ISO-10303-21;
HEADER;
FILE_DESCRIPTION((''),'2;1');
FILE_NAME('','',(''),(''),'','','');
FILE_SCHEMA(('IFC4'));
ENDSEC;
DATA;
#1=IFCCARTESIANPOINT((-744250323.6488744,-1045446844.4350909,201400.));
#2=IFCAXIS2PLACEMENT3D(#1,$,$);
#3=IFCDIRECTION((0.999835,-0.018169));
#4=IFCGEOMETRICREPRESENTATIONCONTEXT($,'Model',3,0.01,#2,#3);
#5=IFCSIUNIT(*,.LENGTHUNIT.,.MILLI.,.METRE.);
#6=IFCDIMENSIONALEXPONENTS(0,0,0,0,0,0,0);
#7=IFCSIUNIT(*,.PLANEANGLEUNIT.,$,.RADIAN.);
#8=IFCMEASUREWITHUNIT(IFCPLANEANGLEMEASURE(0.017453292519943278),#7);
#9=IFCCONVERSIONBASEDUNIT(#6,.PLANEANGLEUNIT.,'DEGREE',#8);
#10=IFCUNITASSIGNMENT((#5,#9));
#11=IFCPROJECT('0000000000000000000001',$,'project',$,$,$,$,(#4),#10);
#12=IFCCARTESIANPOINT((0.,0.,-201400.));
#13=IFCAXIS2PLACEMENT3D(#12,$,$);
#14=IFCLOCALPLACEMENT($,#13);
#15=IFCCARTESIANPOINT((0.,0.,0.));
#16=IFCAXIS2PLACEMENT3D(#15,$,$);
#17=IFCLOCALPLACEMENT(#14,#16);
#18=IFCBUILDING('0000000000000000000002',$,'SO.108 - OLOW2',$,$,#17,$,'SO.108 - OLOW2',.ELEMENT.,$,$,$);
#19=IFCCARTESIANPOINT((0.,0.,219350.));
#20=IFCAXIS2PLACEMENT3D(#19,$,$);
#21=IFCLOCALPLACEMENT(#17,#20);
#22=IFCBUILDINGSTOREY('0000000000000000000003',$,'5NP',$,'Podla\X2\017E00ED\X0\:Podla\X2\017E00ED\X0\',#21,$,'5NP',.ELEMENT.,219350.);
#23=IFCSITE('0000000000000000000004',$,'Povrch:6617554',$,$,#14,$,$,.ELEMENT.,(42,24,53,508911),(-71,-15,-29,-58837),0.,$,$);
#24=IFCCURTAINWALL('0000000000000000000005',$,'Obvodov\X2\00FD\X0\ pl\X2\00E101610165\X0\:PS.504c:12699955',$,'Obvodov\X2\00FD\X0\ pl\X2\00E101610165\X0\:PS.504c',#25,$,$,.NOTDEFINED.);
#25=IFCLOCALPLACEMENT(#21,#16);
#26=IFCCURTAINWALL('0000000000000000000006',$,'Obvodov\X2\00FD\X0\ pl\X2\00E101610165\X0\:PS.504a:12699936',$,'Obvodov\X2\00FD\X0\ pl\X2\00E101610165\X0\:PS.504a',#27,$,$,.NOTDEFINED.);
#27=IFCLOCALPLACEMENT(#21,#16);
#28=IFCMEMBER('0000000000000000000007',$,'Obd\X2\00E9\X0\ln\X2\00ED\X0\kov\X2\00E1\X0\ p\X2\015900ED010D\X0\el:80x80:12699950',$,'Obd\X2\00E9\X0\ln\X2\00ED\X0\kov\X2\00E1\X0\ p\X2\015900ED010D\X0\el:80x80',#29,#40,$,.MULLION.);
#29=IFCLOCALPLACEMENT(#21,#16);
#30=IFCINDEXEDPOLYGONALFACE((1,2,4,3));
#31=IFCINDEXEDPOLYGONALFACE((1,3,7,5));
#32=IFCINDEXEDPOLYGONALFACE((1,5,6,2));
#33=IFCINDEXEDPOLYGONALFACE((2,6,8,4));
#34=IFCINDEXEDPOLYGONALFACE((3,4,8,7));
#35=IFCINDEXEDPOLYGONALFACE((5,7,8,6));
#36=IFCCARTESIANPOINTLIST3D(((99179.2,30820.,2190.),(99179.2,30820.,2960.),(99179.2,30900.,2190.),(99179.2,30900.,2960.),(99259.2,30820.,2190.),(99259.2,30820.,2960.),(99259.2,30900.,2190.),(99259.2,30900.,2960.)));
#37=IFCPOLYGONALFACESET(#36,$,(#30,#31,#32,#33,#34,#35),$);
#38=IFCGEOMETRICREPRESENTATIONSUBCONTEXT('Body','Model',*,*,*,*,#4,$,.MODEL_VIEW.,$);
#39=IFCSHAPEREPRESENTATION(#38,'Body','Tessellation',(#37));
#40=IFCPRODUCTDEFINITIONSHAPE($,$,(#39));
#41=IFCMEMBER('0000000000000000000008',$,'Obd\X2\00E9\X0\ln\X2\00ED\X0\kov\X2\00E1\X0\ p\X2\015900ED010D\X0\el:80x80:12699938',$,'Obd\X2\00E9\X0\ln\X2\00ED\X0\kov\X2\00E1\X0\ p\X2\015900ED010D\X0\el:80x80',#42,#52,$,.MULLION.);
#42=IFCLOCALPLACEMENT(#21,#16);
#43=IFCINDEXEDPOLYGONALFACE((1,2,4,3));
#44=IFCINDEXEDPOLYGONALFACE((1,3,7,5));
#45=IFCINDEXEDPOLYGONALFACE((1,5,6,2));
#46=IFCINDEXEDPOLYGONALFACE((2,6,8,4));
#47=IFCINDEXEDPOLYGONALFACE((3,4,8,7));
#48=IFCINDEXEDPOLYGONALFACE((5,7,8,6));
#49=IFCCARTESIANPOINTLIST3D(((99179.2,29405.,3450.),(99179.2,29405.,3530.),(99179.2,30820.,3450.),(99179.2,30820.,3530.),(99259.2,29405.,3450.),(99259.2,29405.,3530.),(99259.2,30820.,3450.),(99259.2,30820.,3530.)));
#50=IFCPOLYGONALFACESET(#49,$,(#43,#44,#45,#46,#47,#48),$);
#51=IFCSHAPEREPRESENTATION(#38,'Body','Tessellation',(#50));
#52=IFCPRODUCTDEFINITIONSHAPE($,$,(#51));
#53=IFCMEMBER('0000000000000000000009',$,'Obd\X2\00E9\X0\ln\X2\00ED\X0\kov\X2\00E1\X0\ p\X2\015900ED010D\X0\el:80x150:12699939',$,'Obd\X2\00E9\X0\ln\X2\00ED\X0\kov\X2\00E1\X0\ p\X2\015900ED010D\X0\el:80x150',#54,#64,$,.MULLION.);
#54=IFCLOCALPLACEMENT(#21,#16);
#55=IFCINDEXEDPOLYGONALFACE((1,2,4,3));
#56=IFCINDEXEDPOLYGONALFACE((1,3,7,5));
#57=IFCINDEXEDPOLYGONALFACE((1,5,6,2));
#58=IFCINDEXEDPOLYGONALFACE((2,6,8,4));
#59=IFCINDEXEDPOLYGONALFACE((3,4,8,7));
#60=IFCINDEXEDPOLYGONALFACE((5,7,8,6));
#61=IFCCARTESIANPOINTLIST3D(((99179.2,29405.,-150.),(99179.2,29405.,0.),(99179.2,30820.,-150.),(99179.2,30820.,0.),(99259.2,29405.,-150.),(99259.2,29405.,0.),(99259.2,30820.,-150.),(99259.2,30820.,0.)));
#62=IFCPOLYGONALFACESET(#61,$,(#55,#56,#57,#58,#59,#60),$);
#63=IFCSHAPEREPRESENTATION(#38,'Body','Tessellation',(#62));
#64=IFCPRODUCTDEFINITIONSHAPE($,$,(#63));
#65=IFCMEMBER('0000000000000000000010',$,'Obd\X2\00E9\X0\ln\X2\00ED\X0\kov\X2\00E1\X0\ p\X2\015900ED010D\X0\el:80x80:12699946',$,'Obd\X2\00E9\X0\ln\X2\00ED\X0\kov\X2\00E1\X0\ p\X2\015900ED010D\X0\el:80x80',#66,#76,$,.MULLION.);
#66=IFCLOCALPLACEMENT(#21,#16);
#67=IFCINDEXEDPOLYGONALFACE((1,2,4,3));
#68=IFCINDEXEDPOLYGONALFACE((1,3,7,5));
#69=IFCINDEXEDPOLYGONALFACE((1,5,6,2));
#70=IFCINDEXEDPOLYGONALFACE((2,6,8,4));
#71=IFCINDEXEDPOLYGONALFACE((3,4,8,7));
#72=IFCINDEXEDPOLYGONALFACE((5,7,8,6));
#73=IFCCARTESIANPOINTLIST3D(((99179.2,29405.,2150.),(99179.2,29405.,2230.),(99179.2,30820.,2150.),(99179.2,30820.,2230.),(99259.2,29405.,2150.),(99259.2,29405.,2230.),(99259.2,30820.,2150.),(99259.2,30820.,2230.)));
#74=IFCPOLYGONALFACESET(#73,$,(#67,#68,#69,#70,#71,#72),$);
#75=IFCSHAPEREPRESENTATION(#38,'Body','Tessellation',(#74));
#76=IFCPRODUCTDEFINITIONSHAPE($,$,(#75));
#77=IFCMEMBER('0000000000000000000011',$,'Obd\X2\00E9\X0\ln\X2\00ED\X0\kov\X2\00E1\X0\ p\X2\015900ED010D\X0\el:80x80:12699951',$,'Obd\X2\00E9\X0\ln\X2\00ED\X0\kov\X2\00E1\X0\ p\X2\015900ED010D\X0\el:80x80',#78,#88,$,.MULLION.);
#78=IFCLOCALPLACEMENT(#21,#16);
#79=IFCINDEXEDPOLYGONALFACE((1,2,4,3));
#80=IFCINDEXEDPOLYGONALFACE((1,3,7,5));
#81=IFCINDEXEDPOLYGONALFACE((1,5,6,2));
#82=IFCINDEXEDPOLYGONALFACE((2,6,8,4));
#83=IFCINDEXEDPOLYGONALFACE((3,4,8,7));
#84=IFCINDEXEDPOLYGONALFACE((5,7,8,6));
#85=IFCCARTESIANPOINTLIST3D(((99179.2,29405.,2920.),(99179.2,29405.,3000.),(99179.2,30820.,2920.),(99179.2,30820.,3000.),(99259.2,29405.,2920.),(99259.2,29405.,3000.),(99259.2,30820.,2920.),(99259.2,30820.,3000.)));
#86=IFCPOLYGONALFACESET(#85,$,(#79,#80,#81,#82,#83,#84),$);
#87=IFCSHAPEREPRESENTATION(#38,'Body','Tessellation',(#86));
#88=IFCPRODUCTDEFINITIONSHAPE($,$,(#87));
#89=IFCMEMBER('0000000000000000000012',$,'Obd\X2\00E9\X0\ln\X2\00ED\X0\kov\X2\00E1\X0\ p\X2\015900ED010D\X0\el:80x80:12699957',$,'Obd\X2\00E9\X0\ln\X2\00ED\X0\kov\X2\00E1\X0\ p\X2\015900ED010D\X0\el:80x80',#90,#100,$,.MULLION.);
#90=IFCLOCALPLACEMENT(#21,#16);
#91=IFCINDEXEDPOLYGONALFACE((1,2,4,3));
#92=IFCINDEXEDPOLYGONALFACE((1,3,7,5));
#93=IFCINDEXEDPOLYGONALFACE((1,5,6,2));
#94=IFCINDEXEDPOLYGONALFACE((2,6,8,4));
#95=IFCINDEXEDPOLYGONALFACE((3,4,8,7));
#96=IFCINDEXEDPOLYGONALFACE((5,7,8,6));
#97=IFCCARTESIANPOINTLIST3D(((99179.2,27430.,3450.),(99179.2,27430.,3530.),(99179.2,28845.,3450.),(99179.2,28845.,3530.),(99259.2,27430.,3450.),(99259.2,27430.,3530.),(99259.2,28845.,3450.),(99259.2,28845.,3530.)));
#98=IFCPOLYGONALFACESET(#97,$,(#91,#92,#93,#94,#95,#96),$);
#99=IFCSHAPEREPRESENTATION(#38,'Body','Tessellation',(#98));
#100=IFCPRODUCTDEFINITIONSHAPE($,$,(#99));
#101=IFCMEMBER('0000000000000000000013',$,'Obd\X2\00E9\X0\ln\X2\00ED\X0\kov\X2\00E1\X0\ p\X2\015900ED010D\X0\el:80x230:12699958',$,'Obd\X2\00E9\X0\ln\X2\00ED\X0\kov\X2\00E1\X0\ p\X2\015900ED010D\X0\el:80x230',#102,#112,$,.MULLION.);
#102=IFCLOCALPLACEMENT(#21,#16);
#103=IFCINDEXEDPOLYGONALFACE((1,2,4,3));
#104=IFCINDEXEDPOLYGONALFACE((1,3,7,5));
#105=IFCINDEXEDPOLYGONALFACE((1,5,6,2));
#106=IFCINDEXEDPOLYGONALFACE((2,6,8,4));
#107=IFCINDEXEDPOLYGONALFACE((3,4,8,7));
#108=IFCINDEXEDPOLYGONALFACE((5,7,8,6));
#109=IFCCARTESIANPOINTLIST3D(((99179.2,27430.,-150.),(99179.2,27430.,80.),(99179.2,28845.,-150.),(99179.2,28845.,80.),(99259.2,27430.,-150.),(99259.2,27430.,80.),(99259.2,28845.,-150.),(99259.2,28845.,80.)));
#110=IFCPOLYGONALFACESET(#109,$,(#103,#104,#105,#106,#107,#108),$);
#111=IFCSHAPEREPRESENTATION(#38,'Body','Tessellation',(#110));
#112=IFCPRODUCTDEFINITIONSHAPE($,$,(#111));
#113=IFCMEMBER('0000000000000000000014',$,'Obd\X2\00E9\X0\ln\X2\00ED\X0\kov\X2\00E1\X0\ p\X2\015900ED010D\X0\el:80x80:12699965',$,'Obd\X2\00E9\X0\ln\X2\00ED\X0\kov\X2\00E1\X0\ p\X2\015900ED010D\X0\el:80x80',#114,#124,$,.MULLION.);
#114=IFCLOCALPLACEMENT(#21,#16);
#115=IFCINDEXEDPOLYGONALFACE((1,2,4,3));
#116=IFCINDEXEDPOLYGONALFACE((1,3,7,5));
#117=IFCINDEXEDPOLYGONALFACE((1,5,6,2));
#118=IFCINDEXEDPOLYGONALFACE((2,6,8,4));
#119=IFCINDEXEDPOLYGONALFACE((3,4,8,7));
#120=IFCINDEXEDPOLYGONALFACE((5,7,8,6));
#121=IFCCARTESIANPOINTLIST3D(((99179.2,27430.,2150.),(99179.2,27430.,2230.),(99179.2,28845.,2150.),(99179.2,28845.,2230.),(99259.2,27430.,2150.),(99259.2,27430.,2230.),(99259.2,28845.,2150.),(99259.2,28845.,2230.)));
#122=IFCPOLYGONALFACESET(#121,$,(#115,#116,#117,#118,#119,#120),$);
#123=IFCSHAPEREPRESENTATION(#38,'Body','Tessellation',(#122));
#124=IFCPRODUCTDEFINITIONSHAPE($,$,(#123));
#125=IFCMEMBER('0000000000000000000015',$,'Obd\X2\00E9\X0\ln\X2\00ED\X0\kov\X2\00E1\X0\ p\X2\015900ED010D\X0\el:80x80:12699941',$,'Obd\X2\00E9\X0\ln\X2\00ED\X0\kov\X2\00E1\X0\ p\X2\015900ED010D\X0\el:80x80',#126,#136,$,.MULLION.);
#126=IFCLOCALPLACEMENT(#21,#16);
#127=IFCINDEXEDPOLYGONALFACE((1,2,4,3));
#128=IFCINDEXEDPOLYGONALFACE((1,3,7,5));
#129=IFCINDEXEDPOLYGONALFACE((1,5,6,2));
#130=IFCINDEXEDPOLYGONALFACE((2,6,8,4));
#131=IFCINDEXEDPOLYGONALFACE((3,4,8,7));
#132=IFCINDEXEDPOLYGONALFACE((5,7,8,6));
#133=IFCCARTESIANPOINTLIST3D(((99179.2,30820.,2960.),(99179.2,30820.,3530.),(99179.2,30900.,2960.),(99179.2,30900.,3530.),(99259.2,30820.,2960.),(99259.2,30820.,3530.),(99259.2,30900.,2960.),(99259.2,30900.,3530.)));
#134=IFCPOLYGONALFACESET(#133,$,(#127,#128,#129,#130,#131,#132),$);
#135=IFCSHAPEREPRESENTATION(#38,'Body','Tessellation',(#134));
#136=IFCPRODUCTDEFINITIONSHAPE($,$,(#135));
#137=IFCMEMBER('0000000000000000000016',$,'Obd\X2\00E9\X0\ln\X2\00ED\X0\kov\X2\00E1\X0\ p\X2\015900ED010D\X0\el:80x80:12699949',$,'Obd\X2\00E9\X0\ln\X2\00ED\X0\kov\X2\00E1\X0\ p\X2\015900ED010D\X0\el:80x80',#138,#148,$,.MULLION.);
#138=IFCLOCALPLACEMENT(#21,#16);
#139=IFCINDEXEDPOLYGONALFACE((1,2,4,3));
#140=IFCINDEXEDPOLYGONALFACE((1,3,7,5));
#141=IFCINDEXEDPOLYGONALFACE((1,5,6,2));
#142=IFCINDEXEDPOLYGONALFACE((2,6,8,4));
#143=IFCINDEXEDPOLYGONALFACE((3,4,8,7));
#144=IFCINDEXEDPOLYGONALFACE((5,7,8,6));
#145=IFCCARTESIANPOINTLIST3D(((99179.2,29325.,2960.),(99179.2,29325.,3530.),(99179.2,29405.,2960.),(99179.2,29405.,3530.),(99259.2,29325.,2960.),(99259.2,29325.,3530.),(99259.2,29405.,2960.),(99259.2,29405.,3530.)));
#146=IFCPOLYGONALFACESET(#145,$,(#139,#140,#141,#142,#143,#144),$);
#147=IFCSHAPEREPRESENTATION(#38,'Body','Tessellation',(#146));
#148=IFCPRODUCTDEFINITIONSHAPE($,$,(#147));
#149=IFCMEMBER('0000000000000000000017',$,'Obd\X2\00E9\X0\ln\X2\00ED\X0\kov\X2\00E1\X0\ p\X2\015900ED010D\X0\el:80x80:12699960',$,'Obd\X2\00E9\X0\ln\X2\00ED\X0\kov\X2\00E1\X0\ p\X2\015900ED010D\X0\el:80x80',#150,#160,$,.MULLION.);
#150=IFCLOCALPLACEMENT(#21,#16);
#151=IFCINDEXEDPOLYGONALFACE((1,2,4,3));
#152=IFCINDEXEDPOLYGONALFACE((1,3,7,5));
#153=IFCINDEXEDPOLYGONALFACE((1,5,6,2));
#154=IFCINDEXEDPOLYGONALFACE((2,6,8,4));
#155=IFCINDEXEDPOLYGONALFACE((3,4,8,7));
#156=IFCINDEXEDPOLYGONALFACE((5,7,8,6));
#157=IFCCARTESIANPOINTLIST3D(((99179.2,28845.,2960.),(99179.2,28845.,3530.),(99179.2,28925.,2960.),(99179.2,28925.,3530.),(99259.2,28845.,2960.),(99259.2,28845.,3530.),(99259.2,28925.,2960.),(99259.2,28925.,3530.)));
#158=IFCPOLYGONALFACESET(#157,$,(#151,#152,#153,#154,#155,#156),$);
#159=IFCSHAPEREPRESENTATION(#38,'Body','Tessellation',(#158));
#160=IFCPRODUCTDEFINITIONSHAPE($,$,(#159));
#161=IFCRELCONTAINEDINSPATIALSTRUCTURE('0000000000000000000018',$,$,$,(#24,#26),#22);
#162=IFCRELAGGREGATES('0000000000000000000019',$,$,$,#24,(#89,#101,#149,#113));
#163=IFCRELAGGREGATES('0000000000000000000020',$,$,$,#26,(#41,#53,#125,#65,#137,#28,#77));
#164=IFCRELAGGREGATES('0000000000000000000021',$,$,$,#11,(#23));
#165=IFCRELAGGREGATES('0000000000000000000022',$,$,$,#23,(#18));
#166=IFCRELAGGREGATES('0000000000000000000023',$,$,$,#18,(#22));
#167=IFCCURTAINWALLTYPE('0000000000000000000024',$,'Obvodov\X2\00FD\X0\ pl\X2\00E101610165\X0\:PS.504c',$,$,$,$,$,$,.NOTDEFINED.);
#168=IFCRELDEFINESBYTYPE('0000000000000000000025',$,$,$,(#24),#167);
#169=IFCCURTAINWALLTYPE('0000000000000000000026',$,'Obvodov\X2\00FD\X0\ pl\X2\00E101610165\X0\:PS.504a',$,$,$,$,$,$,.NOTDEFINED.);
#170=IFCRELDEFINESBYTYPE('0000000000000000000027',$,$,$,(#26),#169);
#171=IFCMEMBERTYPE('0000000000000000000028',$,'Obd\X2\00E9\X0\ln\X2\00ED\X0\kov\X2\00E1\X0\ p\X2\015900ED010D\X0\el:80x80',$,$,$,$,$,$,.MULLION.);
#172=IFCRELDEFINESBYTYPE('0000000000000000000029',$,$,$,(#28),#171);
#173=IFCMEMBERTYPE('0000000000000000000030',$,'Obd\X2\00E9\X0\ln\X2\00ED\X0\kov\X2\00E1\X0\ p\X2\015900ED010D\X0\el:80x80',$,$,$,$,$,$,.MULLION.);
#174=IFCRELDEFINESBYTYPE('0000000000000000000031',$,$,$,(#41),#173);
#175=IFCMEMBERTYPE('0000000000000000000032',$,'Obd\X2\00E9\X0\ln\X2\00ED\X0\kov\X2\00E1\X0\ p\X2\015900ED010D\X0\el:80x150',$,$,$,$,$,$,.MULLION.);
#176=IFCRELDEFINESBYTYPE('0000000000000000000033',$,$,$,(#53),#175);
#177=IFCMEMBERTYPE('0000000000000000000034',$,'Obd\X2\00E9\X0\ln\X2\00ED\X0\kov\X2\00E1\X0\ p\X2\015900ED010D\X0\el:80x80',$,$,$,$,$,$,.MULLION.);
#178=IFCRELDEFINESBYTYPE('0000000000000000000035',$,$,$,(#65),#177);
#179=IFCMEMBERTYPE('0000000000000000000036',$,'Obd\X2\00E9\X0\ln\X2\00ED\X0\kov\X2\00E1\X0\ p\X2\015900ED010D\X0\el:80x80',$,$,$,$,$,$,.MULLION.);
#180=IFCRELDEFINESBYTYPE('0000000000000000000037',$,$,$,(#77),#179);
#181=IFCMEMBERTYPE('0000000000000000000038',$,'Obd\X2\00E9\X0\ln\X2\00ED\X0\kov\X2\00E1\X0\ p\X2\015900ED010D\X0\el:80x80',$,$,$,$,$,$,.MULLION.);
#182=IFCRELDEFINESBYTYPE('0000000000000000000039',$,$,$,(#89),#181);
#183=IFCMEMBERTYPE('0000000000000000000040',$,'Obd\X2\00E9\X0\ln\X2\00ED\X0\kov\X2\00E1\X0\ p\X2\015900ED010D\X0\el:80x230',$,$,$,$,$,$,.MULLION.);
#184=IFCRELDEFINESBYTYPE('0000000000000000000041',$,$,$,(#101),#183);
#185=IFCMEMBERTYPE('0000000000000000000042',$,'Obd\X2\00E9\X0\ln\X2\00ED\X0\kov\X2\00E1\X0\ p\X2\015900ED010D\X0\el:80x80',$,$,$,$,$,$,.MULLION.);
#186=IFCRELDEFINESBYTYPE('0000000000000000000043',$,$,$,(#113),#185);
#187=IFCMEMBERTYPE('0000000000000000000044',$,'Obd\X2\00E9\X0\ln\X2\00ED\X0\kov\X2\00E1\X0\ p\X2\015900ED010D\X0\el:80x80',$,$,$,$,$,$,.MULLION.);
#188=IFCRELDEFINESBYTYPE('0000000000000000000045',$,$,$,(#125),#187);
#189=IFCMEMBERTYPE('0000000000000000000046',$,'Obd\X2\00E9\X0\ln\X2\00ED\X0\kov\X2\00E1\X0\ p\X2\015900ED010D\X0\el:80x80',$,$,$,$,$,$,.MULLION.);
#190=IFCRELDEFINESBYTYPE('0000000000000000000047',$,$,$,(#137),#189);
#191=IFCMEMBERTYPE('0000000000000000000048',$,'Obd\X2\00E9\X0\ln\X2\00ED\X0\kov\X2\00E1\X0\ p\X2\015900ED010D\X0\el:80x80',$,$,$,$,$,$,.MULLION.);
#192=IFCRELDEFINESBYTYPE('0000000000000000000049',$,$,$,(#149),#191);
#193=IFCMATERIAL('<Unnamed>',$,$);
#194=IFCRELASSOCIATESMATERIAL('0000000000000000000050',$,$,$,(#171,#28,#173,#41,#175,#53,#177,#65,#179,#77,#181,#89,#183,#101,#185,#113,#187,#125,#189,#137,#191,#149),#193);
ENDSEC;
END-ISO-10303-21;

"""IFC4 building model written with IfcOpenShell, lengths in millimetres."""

from ifc_helpers import new_model, entity, si_unit, converted_unit, direction, frame, origin, place, context, subcontext, project, spatial, indexed_curve, outline, extrude, source, transform, mapped, material, type_object, type_shapes, element, aggregate, save


model = new_model("IFC4")

# Units and contexts
model_context = context("Model", 3, precision=0.01, world=frame((-744250323.6488744, -1045446844.4350909, 201400.0)), true_north=direction((0.999835, -0.018169)))
body_context = subcontext(model_context, "Body", "Model", "MODEL_VIEW")
ifc_project = project(units=[si_unit("LENGTHUNIT", "METRE", prefix="MILLI"), converted_unit("PLANEANGLEUNIT", "DEGREE", entity("IfcPlaneAngleMeasure", 0.017453292519943278), si_unit("PLANEANGLEUNIT", "RADIAN"), dimensions=[0, 0, 0, 0, 0, 0, 0])], contexts=[model_context])

# Site, building, storey
site_placement = place(None, frame((0.0, 0.0, -201400.0)))
site = spatial("IfcSite", under=ifc_project, at=site_placement, Name="Povrch:6617554", CompositionType="ELEMENT", RefLatitude=(42, 24, 53, 508911), RefLongitude=(-71, -15, -29, -58837), RefElevation=0.0)
building_placement = place(site_placement, origin())
building = spatial("IfcBuilding", under=site, at=building_placement, Name="SO.108 - OLOW2", LongName="SO.108 - OLOW2", CompositionType="ELEMENT")
storey_placement = place(building_placement, frame((0.0, 0.0, 219350.0)))
storey = spatial("IfcBuildingStorey", under=building, at=storey_placement, Name="5NP", ObjectType="Podlaží:Podlaží", LongName="5NP", CompositionType="ELEMENT", Elevation=219350.0)

# Curtain walls, members
ifc_material_1 = material(Name="<Unnamed>")
curtain_wall_type_1 = type_object("IfcCurtainWallType", Name="Obvodový plášť:PS.504c", PredefinedType="NOTDEFINED")
curtain_wall_1_placement = place(storey_placement, frame((0.0, 0.0, -219350.0)))
curtain_wall_1 = element("IfcCurtainWall", 1, at=curtain_wall_1_placement, inside=storey, type_object=curtain_wall_type_1, Name="Obvodový plášť:PS.504c:12699955", ObjectType="Obvodový plášť:PS.504c", PredefinedType="NOTDEFINED")
curtain_wall_type_2 = type_object("IfcCurtainWallType", Name="Obvodový plášť:PS.504a", PredefinedType="NOTDEFINED")
curtain_wall_2_placement = place(storey_placement, frame((0.0, 0.0, -219350.0)))
curtain_wall_2 = element("IfcCurtainWall", 2, at=curtain_wall_2_placement, inside=storey, type_object=curtain_wall_type_2, Name="Obvodový plášť:PS.504a:12699936", ObjectType="Obvodový plášť:PS.504a", PredefinedType="NOTDEFINED")
member_type_1 = type_object("IfcMemberType", Name="Obdélníková příčel:80x80", PredefinedType="MULLION", material=ifc_material_1)
shared_shape_1 = source(origin(), body_context, "Body", "SweptSolid", [
    extrude(outline(indexed_curve([(-40.0, -40.0), (40.0, -40.0), (40.0, 40.0), (-40.0, 40.0), (-40.0, -40.0)], self_intersect=False)), frame((-40.0, 0.0, -770.0), z_axis=(0.0, 0.0, 1.0), x_axis=(-1.0, 0.0, 0.0)), (0.0, 0.0, 1.0), 770.0),
])
type_shapes(member_type_1, [shared_shape_1])
member_1_placement = place(curtain_wall_2_placement, frame((99219.2, 30900.0, 222310.0), z_axis=(0.0, 0.0, 1.0), x_axis=(0.0, 1.0, 0.0)))
member_1 = element("IfcMember", 3, at=member_1_placement, type_object=member_type_1, material=ifc_material_1, Name="Obdélníková příčel:80x80:12699950", ObjectType="Obdélníková příčel:80x80", PredefinedType="MULLION", context=body_context, shape_type="MappedRepresentation", body=[
    mapped(shared_shape_1, transform((0.0, 0.0, 0.0), scale=1.0)),
])
member_type_2 = type_object("IfcMemberType", Name="Obdélníková příčel:80x80", PredefinedType="MULLION", material=ifc_material_1)
shared_shape_2 = source(origin(), body_context, "Body", "SweptSolid", [
    extrude(outline(indexed_curve([(-40.0, -40.0), (40.0, -40.0), (40.0, 40.0), (-40.0, 40.0), (-40.0, -40.0)], self_intersect=False)), frame((-40.0, 0.0, -1415.0), z_axis=(0.0, 0.0, 1.0), x_axis=(-1.0, 0.0, 0.0)), (0.0, 0.0, 1.0), 1415.0),
])
type_shapes(member_type_2, [shared_shape_2])
member_2_placement = place(curtain_wall_2_placement, frame((99219.2, 29405.0, 222880.0), z_axis=(0.0, -1.0, 0.0), x_axis=(0.0, 0.0, 1.0)))
member_2 = element("IfcMember", 4, at=member_2_placement, type_object=member_type_2, material=ifc_material_1, Name="Obdélníková příčel:80x80:12699938", ObjectType="Obdélníková příčel:80x80", PredefinedType="MULLION", context=body_context, shape_type="MappedRepresentation", body=[
    mapped(shared_shape_2, transform((0.0, 0.0, 0.0), scale=1.0)),
])
member_type_3 = type_object("IfcMemberType", Name="Obdélníková příčel:80x150", PredefinedType="MULLION", material=ifc_material_1)
shared_shape_3 = source(origin(), body_context, "Body", "SweptSolid", [
    extrude(outline(indexed_curve([(-75.0, -40.0), (75.0, -40.0), (75.0, 40.0), (-75.0, 40.0), (-75.0, -40.0)], self_intersect=False)), frame((-75.0, 0.0, -1415.0), z_axis=(0.0, 0.0, 1.0), x_axis=(-1.0, 0.0, 0.0)), (0.0, 0.0, 1.0), 1415.0),
])
type_shapes(member_type_3, [shared_shape_3])
member_3_placement = place(curtain_wall_2_placement, frame((99219.2, 30820.0, 219200.0), z_axis=(0.0, 1.0, 0.0), x_axis=(0.0, 0.0, -1.0)))
member_3 = element("IfcMember", 5, at=member_3_placement, type_object=member_type_3, material=ifc_material_1, Name="Obdélníková příčel:80x150:12699939", ObjectType="Obdélníková příčel:80x150", PredefinedType="MULLION", context=body_context, shape_type="MappedRepresentation", body=[
    mapped(shared_shape_3, transform((0.0, 0.0, 0.0), scale=1.0)),
])
member_type_4 = type_object("IfcMemberType", Name="Obdélníková příčel:80x80", PredefinedType="MULLION", material=ifc_material_1)
shared_shape_4 = source(origin(), body_context, "Body", "SweptSolid", [
    extrude(outline(indexed_curve([(-40.0, -40.0), (40.0, -40.0), (40.0, 40.0), (-40.0, 40.0), (-40.0, -40.0)], self_intersect=False)), frame((0.0, 0.0, -1415.0), z_axis=(0.0, 0.0, 1.0), x_axis=(-1.0, 0.0, 0.0)), (0.0, 0.0, 1.0), 1415.0),
])
type_shapes(member_type_4, [shared_shape_4])
member_4_placement = place(curtain_wall_2_placement, frame((99219.2, 29405.0, 221540.0), z_axis=(0.0, -1.0, 0.0), x_axis=(0.0, 0.0, 1.0)))
member_4 = element("IfcMember", 6, at=member_4_placement, type_object=member_type_4, material=ifc_material_1, Name="Obdélníková příčel:80x80:12699946", ObjectType="Obdélníková příčel:80x80", PredefinedType="MULLION", context=body_context, shape_type="MappedRepresentation", body=[
    mapped(shared_shape_4, transform((0.0, 0.0, 0.0), scale=1.0)),
])
member_type_5 = type_object("IfcMemberType", Name="Obdélníková příčel:80x80", PredefinedType="MULLION", material=ifc_material_1)
shared_shape_5 = source(origin(), body_context, "Body", "SweptSolid", [
    extrude(outline(indexed_curve([(-40.0, -40.0), (40.0, -40.0), (40.0, 40.0), (-40.0, 40.0), (-40.0, -40.0)], self_intersect=False)), frame((0.0, 0.0, -1415.0), z_axis=(0.0, 0.0, 1.0), x_axis=(-1.0, 0.0, 0.0)), (0.0, 0.0, 1.0), 1415.0),
])
type_shapes(member_type_5, [shared_shape_5])
member_5_placement = place(curtain_wall_2_placement, frame((99219.2, 29405.0, 222310.0), z_axis=(0.0, -1.0, 0.0), x_axis=(0.0, 0.0, 1.0)))
member_5 = element("IfcMember", 7, at=member_5_placement, type_object=member_type_5, material=ifc_material_1, Name="Obdélníková příčel:80x80:12699951", ObjectType="Obdélníková příčel:80x80", PredefinedType="MULLION", context=body_context, shape_type="MappedRepresentation", body=[
    mapped(shared_shape_5, transform((0.0, 0.0, 0.0), scale=1.0)),
])

# Members
member_type_6 = type_object("IfcMemberType", Name="Obdélníková příčel:80x80", PredefinedType="MULLION", material=ifc_material_1)
shared_shape_6 = source(origin(), body_context, "Body", "SweptSolid", [
    extrude(outline(indexed_curve([(-40.0, -40.0), (40.0, -40.0), (40.0, 40.0), (-40.0, 40.0), (-40.0, -40.0)], self_intersect=False)), frame((-40.0, 0.0, -1415.0), z_axis=(0.0, 0.0, 1.0), x_axis=(-1.0, 0.0, 0.0)), (0.0, 0.0, 1.0), 1415.0),
])
type_shapes(member_type_6, [shared_shape_6])
member_6_placement = place(curtain_wall_1_placement, frame((99219.2, 27430.0, 222880.0), z_axis=(0.0, -1.0, 0.0), x_axis=(0.0, 0.0, 1.0)))
member_6 = element("IfcMember", 8, at=member_6_placement, type_object=member_type_6, material=ifc_material_1, Name="Obdélníková příčel:80x80:12699957", ObjectType="Obdélníková příčel:80x80", PredefinedType="MULLION", context=body_context, shape_type="MappedRepresentation", body=[
    mapped(shared_shape_6, transform((0.0, 0.0, 0.0), scale=1.0)),
])
member_type_7 = type_object("IfcMemberType", Name="Obdélníková příčel:80x230", PredefinedType="MULLION", material=ifc_material_1)
shared_shape_7 = source(origin(), body_context, "Body", "SweptSolid", [
    extrude(outline(indexed_curve([(-115.0, -40.0), (115.0, -40.0), (115.0, 40.0), (-115.0, 40.0), (-115.0, -40.0)], self_intersect=False)), frame((-115.0, 0.0, -1415.0), z_axis=(0.0, 0.0, 1.0), x_axis=(-1.0, 0.0, 0.0)), (0.0, 0.0, 1.0), 1415.0),
])
type_shapes(member_type_7, [shared_shape_7])
member_7_placement = place(curtain_wall_1_placement, frame((99219.2, 28845.0, 219200.0), z_axis=(0.0, 1.0, 0.0), x_axis=(0.0, 0.0, -1.0)))
member_7 = element("IfcMember", 9, at=member_7_placement, type_object=member_type_7, material=ifc_material_1, Name="Obdélníková příčel:80x230:12699958", ObjectType="Obdélníková příčel:80x230", PredefinedType="MULLION", context=body_context, shape_type="MappedRepresentation", body=[
    mapped(shared_shape_7, transform((0.0, 0.0, 0.0), scale=1.0)),
])
member_type_8 = type_object("IfcMemberType", Name="Obdélníková příčel:80x80", PredefinedType="MULLION", material=ifc_material_1)
shared_shape_8 = source(origin(), body_context, "Body", "SweptSolid", [
    extrude(outline(indexed_curve([(-40.0, -40.0), (40.0, -40.0), (40.0, 40.0), (-40.0, 40.0), (-40.0, -40.0)], self_intersect=False)), frame((0.0, 0.0, -1415.0), z_axis=(0.0, 0.0, 1.0), x_axis=(-1.0, 0.0, 0.0)), (0.0, 0.0, 1.0), 1415.0),
])
type_shapes(member_type_8, [shared_shape_8])
member_8_placement = place(curtain_wall_1_placement, frame((99219.2, 27430.0, 221540.0), z_axis=(0.0, -1.0, 0.0), x_axis=(0.0, 0.0, 1.0)))
member_8 = element("IfcMember", 10, at=member_8_placement, type_object=member_type_8, material=ifc_material_1, Name="Obdélníková příčel:80x80:12699965", ObjectType="Obdélníková příčel:80x80", PredefinedType="MULLION", context=body_context, shape_type="MappedRepresentation", body=[
    mapped(shared_shape_8, transform((0.0, 0.0, 0.0), scale=1.0)),
])
member_type_9 = type_object("IfcMemberType", Name="Obdélníková příčel:80x80", PredefinedType="MULLION", material=ifc_material_1)
shared_shape_9 = source(origin(), body_context, "Body", "SweptSolid", [
    extrude(outline(indexed_curve([(-40.0, -40.0), (40.0, -40.0), (40.0, 40.0), (-40.0, 40.0), (-40.0, -40.0)], self_intersect=False)), frame((-40.0, 0.0, -570.0), z_axis=(0.0, 0.0, 1.0), x_axis=(-1.0, 0.0, 0.0)), (0.0, 0.0, 1.0), 570.0),
])
type_shapes(member_type_9, [shared_shape_9])
member_9_placement = place(curtain_wall_2_placement, frame((99219.2, 30900.0, 222880.0), z_axis=(0.0, 0.0, 1.0), x_axis=(0.0, 1.0, 0.0)))
member_9 = element("IfcMember", 11, at=member_9_placement, type_object=member_type_9, material=ifc_material_1, Name="Obdélníková příčel:80x80:12699941", ObjectType="Obdélníková příčel:80x80", PredefinedType="MULLION", context=body_context, shape_type="MappedRepresentation", body=[
    mapped(shared_shape_9, transform((0.0, 0.0, 0.0), scale=1.0)),
])
member_type_10 = type_object("IfcMemberType", Name="Obdélníková příčel:80x80", PredefinedType="MULLION", material=ifc_material_1)
shared_shape_10 = source(origin(), body_context, "Body", "SweptSolid", [
    extrude(outline(indexed_curve([(-40.0, -40.0), (40.0, -40.0), (40.0, 40.0), (-40.0, 40.0), (-40.0, -40.0)], self_intersect=False)), frame((-40.0, 0.0, -570.0), z_axis=(0.0, 0.0, 1.0), x_axis=(-1.0, 0.0, 0.0)), (0.0, 0.0, 1.0), 570.0),
])
type_shapes(member_type_10, [shared_shape_10])
member_10_placement = place(curtain_wall_2_placement, frame((99219.2, 29325.0, 222310.0), z_axis=(0.0, 0.0, -1.0), x_axis=(0.0, -1.0, 0.0)))
member_10 = element("IfcMember", 12, at=member_10_placement, type_object=member_type_10, material=ifc_material_1, Name="Obdélníková příčel:80x80:12699949", ObjectType="Obdélníková příčel:80x80", PredefinedType="MULLION", context=body_context, shape_type="MappedRepresentation", body=[
    mapped(shared_shape_10, transform((0.0, 0.0, 0.0), scale=1.0)),
])
member_type_11 = type_object("IfcMemberType", Name="Obdélníková příčel:80x80", PredefinedType="MULLION", material=ifc_material_1)
shared_shape_11 = source(origin(), body_context, "Body", "SweptSolid", [
    extrude(outline(indexed_curve([(-40.0, -40.0), (40.0, -40.0), (40.0, 40.0), (-40.0, 40.0), (-40.0, -40.0)], self_intersect=False)), frame((-40.0, 0.0, -570.0), z_axis=(0.0, 0.0, 1.0), x_axis=(-1.0, 0.0, 0.0)), (0.0, 0.0, 1.0), 570.0),
])
type_shapes(member_type_11, [shared_shape_11])
member_11_placement = place(curtain_wall_1_placement, frame((99219.2, 28925.0, 222880.0), z_axis=(0.0, 0.0, 1.0), x_axis=(0.0, 1.0, 0.0)))
member_11 = element("IfcMember", 13, at=member_11_placement, type_object=member_type_11, material=ifc_material_1, Name="Obdélníková příčel:80x80:12699960", ObjectType="Obdélníková příčel:80x80", PredefinedType="MULLION", context=body_context, shape_type="MappedRepresentation", body=[
    mapped(shared_shape_11, transform((0.0, 0.0, 0.0), scale=1.0)),
])

aggregate(curtain_wall_1, [member_6, member_7, member_11, member_8])

aggregate(curtain_wall_2, [member_2, member_3, member_9, member_4, member_10, member_1, member_5])

save(model, "model.ifc")
